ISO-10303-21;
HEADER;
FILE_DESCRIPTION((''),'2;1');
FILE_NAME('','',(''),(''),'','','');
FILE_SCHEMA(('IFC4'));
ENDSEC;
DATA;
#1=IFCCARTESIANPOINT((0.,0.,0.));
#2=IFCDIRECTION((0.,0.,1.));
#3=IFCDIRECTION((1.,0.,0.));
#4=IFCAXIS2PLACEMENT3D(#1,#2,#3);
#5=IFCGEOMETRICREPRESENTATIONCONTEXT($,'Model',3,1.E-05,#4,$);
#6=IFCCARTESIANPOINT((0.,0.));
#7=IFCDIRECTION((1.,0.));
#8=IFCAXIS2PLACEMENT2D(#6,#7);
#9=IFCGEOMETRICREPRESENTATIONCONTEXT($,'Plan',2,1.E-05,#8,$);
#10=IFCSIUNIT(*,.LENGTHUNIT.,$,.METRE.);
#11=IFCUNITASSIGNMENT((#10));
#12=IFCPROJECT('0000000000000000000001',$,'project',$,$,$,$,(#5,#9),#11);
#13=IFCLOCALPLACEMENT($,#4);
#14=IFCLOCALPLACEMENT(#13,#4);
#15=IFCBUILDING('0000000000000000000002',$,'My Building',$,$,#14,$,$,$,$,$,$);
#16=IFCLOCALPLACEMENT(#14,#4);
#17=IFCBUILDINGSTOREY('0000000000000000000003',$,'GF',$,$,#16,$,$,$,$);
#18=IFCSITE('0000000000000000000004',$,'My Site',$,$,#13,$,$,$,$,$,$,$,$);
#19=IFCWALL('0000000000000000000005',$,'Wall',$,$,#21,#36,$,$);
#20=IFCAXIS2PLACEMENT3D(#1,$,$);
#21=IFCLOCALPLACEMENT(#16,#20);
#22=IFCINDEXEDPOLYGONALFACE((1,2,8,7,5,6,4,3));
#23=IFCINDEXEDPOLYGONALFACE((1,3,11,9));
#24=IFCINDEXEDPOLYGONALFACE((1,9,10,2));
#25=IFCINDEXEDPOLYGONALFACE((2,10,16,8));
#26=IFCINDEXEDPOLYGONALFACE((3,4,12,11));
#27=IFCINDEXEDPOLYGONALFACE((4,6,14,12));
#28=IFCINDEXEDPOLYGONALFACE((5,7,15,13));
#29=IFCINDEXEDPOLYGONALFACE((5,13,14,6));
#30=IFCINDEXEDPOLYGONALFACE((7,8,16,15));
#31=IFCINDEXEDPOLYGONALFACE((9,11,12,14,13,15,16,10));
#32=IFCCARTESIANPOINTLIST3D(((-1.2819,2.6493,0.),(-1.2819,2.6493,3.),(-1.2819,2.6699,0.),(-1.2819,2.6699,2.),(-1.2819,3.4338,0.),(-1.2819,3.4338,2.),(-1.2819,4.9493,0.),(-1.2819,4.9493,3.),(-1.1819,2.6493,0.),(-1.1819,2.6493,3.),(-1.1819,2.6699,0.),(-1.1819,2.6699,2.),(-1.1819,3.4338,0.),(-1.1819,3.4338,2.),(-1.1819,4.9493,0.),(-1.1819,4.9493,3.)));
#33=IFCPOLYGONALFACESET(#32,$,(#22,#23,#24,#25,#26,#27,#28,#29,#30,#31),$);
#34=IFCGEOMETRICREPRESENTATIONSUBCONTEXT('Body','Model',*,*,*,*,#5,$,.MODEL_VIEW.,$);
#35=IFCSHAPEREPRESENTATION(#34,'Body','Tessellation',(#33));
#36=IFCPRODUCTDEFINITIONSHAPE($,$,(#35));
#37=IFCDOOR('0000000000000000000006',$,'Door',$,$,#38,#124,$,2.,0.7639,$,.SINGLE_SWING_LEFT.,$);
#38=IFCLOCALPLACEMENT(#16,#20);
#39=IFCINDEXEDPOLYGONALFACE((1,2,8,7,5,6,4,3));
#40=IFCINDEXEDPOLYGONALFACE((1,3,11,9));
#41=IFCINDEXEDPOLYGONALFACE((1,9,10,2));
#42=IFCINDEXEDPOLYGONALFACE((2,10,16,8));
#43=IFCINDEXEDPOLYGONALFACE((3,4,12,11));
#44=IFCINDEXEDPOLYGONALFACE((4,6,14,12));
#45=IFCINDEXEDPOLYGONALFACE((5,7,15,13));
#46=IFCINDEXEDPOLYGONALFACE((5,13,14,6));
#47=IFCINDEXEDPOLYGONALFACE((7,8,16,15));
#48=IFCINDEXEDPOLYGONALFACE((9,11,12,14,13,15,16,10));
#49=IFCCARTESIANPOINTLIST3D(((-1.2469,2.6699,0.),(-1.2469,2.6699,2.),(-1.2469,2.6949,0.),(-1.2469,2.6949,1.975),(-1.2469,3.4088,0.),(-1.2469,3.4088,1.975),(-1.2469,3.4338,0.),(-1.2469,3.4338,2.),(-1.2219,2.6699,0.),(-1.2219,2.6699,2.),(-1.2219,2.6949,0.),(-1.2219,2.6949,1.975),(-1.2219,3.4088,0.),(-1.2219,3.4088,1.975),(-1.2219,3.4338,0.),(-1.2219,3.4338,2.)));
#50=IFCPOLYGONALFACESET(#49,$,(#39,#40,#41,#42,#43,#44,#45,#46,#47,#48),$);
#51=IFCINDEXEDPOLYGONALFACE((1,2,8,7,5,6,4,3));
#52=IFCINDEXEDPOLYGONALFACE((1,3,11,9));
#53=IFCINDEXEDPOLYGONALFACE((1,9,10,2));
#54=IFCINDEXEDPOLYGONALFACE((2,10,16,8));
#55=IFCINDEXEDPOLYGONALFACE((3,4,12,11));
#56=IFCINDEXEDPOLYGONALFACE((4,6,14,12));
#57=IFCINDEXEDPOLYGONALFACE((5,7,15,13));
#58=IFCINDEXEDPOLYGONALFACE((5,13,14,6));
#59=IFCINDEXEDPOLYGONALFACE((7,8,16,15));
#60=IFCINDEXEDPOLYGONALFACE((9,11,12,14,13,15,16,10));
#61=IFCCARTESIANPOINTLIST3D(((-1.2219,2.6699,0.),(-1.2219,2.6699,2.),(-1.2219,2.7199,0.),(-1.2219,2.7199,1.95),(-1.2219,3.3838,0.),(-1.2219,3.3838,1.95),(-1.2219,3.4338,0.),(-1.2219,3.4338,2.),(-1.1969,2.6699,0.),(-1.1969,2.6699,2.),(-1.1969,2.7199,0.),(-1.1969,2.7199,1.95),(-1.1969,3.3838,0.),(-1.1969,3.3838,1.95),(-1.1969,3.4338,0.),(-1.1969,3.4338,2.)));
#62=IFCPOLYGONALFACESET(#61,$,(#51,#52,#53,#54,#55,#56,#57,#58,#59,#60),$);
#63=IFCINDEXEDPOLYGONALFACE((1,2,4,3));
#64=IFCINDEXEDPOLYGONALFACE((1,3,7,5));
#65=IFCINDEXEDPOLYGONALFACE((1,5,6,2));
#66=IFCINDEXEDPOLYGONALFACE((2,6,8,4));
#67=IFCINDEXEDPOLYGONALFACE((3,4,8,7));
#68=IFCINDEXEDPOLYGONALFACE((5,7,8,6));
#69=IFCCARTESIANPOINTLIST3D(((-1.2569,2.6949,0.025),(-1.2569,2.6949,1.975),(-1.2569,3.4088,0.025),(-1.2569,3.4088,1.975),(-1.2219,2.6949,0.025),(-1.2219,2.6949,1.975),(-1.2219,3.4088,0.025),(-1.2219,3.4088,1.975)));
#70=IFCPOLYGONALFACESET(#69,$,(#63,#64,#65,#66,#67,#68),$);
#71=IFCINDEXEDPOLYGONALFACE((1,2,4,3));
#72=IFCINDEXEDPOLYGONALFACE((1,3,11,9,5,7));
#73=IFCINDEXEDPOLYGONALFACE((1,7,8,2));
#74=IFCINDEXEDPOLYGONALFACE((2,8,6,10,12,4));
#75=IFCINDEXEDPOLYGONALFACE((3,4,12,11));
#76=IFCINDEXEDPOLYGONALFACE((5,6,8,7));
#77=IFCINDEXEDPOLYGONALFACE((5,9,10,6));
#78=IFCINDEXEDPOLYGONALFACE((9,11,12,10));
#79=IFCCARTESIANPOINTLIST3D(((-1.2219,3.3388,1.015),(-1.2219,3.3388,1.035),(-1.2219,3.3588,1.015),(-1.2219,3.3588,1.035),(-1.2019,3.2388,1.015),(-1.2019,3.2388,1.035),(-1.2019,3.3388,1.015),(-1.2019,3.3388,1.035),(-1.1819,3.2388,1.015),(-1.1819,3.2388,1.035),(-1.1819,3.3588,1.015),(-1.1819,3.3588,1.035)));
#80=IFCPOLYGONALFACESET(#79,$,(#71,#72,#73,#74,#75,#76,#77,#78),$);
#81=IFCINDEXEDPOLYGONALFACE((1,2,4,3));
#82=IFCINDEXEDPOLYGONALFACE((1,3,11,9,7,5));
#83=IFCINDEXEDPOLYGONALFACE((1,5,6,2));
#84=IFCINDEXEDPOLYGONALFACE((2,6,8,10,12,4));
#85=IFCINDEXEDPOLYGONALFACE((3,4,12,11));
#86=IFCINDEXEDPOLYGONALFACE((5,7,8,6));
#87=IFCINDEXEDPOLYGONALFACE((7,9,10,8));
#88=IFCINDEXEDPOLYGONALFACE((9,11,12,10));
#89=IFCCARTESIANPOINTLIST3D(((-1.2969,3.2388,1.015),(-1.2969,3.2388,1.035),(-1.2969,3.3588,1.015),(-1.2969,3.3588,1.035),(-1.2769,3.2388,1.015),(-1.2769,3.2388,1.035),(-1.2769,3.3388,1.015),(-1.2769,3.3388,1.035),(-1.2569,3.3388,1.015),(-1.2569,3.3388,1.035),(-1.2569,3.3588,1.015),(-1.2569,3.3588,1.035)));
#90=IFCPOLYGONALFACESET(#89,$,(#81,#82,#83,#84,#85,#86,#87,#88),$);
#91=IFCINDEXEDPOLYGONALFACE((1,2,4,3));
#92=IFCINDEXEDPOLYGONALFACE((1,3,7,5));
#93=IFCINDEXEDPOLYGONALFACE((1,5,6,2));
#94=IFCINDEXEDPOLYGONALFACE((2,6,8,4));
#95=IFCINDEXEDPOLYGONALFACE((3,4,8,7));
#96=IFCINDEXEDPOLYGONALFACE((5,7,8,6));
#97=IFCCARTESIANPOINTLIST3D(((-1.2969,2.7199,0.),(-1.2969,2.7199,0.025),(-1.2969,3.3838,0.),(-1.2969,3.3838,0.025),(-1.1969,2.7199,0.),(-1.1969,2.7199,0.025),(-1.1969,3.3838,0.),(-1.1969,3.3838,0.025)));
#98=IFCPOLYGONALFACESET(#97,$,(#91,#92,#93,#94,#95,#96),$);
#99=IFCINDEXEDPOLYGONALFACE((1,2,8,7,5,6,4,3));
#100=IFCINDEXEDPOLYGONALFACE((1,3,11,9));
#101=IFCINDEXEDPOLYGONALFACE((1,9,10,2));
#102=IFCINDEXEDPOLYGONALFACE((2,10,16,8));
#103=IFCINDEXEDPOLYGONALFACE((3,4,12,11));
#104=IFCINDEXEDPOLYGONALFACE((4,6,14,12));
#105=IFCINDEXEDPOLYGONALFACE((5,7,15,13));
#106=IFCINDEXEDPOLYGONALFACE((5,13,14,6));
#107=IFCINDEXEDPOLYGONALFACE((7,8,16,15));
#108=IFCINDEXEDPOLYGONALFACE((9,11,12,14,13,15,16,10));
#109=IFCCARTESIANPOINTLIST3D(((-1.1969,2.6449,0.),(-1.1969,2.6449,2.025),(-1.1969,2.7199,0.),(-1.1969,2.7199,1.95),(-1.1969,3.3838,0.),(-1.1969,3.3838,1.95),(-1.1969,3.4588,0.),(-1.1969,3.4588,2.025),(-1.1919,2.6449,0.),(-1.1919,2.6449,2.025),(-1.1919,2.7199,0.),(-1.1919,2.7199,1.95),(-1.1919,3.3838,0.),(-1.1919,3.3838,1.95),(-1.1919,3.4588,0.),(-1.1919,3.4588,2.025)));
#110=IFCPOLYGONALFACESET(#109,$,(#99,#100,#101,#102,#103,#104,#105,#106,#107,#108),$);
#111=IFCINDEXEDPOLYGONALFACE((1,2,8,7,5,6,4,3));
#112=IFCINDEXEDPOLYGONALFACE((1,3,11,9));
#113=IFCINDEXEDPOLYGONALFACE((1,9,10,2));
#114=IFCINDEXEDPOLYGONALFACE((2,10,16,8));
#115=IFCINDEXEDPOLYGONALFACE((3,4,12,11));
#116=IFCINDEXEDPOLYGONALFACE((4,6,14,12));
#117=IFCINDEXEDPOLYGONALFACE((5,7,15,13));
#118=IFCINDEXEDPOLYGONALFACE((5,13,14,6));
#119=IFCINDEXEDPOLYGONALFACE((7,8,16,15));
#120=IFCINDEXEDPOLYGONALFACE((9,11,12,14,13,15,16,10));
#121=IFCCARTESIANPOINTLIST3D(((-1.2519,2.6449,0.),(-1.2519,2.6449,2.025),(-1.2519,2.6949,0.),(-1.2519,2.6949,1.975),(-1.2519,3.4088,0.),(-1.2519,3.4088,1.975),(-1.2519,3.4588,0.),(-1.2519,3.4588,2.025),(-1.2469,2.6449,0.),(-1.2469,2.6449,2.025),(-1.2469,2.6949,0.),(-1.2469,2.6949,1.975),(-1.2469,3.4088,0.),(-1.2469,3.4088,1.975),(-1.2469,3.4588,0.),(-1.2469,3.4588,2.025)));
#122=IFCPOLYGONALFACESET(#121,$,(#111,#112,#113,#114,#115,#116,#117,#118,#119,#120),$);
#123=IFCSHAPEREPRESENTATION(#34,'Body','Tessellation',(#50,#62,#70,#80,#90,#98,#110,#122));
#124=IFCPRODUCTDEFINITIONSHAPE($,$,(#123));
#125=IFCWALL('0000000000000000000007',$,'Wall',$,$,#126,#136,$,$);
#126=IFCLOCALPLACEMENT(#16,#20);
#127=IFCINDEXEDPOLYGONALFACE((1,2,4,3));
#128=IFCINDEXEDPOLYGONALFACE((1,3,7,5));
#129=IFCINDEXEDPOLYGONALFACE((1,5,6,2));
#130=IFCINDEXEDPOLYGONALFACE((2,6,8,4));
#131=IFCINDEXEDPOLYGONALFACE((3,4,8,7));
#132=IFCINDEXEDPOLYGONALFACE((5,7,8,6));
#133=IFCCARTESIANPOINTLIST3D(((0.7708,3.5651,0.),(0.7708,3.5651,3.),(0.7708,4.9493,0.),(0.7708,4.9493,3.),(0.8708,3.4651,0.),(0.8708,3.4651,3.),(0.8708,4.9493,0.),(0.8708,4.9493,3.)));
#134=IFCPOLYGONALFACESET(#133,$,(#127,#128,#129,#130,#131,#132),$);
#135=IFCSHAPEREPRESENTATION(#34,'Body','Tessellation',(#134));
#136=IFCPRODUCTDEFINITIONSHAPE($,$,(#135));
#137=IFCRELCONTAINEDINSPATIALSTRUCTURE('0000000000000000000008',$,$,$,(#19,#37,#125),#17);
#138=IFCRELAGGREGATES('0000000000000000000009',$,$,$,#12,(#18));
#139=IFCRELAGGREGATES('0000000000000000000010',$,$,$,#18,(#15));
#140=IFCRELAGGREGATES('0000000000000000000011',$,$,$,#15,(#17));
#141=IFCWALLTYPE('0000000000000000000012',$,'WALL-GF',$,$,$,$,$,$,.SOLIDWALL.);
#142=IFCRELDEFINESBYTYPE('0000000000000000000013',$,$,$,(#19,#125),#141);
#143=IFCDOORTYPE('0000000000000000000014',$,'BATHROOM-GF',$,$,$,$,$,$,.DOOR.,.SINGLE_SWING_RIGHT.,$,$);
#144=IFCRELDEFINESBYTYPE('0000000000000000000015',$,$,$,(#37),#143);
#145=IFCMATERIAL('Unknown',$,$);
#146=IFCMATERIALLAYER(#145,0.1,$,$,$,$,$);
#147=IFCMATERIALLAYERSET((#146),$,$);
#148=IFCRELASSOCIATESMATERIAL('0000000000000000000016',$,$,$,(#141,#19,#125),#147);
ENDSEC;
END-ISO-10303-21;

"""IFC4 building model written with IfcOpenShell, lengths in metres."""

from ifc_helpers import new_model, entity, si_unit, frame, origin_with_axes, origin_2d_with_axis, place, context, subcontext, project, spatial, line, indexed_curve, outline, extrude, shape, source, transform, mapped, material, layer, layer_set, layer_usage, type_object, type_shapes, element, fill, save


model = new_model("IFC4")

# Units and contexts
model_context = context("Model", 3, precision=1e-05, world=origin_with_axes())
plan_context = context("Plan", 2, precision=1e-05, world=origin_2d_with_axis())
body_context_1 = subcontext(model_context, "Body", "Model", "MODEL_VIEW")
body_context_2 = subcontext(plan_context, "Body", "Plan", "PLAN_VIEW")
ifc_project = project(units=[si_unit("LENGTHUNIT", "METRE")], contexts=[model_context, plan_context])

# Site, building, storey
site_placement = place(None, origin_with_axes())
site = spatial("IfcSite", under=ifc_project, at=site_placement, Name="My Site")
building_placement = place(site_placement, origin_with_axes())
building = spatial("IfcBuilding", under=site, at=building_placement, Name="My Building")
storey_placement = place(building_placement, origin_with_axes())
storey = spatial("IfcBuildingStorey", under=building, at=storey_placement, Name="GF")

# Shared definitions
ifc_material = material(Name="Unknown")

# Shared definitions
ifc_layer_1 = layer(ifc_material, 0.1)
ifc_layer_set_1 = layer_set([ifc_layer_1])
wall_type = type_object("IfcWallType", Name="WALL-GF", PredefinedType="SOLIDWALL", material=ifc_layer_set_1)

# Wall, opening, door
ifc_layer_usage_1 = layer_usage(ifc_layer_set_1, "AXIS2", "POSITIVE", 0.0)
wall_1_placement = place(storey_placement, frame((-1.1819, 2.6493, 0.0), z_axis=(0.0, 0.0, 1.0), x_axis=(0.0, 1.0, 0.0)))
wall_1 = element("IfcWall", 1, at=wall_1_placement, inside=storey, type_object=wall_type, material=ifc_layer_usage_1, Name="Wall", context=body_context_1, shape_type="SweptSolid", body=[
    extrude(outline(indexed_curve([(0.0, 0.0), (0.0, 0.1), (2.3, 0.1), (2.3, 0.0)], segments=[line(1, 2, 3, 4, 1)])), origin_with_axes(), (0.0, 0.0, 1.0), 3.0),
])
shared_shape_1 = source(origin_with_axes(), body_context_1, "Body", "SweptSolid", [
    extrude(outline(indexed_curve([(0.0, 0.0), (0.7639, 0.0), (0.7639, 2.0), (0.0, 2.0)], segments=[line(1, 2, 3, 4, 1)])), frame((0.0, -0.6, 0.0), z_axis=(0.0, -1.0, 0.0), x_axis=(1.0, 0.0, 0.0)), (0.0, 0.0, -1.0), 1.2),
])
opening_1_placement = place(wall_1_placement, frame((0.0206, 0.015, 0.0), z_axis=(0.0, 0.0, 1.0), x_axis=(1.0, 0.0, 0.0)))
opening_1 = element("IfcOpeningElement", 2, at=opening_1_placement, cuts=wall_1, PredefinedType="OPENING", context=body_context_1, shape_type="MappedRepresentation", body=[
    mapped(shared_shape_1, transform((0.0, 0.0, 0.0), x_axis=(1.0, 0.0, 0.0), y_axis=(0.0, 1.0, 0.0), z_axis=(0.0, 0.0, 1.0), scale=1.0)),
])
door_type_1 = type_object("IfcDoorType", Name="BATHROOM-GF", OperationType="SINGLE_SWING_RIGHT", PredefinedType="DOOR")
shared_shape_2 = source(origin_with_axes(), body_context_1, "Body", "SweptSolid", [
    extrude(outline(indexed_curve([(0.0, 0.0), (0.0, 2.0), (0.7639, 2.0), (0.7639, 0.0), (0.7389, 0.0), (0.7389, 1.975), (0.025, 1.975), (0.025, 0.0)], segments=[line(1, 2, 3, 4, 5, 6, 7, 8, 1)])), frame((0.0, 0.025, 0.0), z_axis=(0.0, -1.0, 0.0), x_axis=(1.0, 0.0, 0.0)), (0.0, 0.0, -1.0), 0.025),
    extrude(outline(indexed_curve([(0.0, 0.0), (0.0, 2.0), (0.7639, 2.0), (0.7639, 0.0), (0.7139, 0.0), (0.7139, 1.95), (0.05, 1.95), (0.05, 0.0)], segments=[line(1, 2, 3, 4, 5, 6, 7, 8, 1)])), frame((0.0, 0.0, 0.0), z_axis=(0.0, -1.0, 0.0), x_axis=(1.0, 0.0, 0.0)), (0.0, 0.0, -1.0), 0.025),
    extrude(outline(indexed_curve([(0.0, 0.0), (0.7139, 0.0), (0.7139, 0.035), (0.0, 0.035)], segments=[line(1, 2, 3, 4, 1)])), frame((0.025, 0.025, 0.025), z_axis=(0.0, 0.0, 1.0), x_axis=(1.0, 0.0, 0.0)), (0.0, 0.0, 1.0), 1.95),
    extrude(outline(indexed_curve([(0.0, 0.0), (0.0, -0.04), (-0.12, -0.04), (-0.12, -0.02), (-0.02, -0.02), (-0.02, 0.0)], segments=[line(1, 2, 3, 4, 5, 6, 1)])), frame((0.6889, 0.025, 1.015), z_axis=(0.0, 0.0, 1.0), x_axis=(1.0, 0.0, 0.0)), (0.0, 0.0, 1.0), 0.02),
    extrude(outline(indexed_curve([(0.0, 0.0), (0.0, 0.04), (-0.12, 0.04), (-0.12, 0.02), (-0.02, 0.02), (-0.02, 0.0)], segments=[line(1, 2, 3, 4, 5, 6, 1)])), frame((0.6889, 0.06, 1.015), z_axis=(0.0, 0.0, 1.0), x_axis=(1.0, 0.0, 0.0)), (0.0, 0.0, 1.0), 0.02),
    extrude(outline(indexed_curve([(0.0, 0.0), (0.6639, 0.0), (0.6639, 0.1), (0.0, 0.1)], segments=[line(1, 2, 3, 4, 1)])), frame((0.05, 0.0, 0.0), z_axis=(0.0, 0.0, 1.0), x_axis=(1.0, 0.0, 0.0)), (0.0, 0.0, 1.0), 0.025),
    extrude(outline(indexed_curve([(0.0, 0.0), (0.0, 2.025), (0.8139, 2.025), (0.8139, 0.0), (0.7389, 0.0), (0.7389, 1.95), (0.075, 1.95), (0.075, 0.0)], segments=[line(1, 2, 3, 4, 5, 6, 7, 8, 1)])), frame((-0.025, -0.005, 0.0), z_axis=(0.0, -1.0, 0.0), x_axis=(1.0, 0.0, 0.0)), (0.0, 0.0, -1.0), 0.005),
    extrude(outline(indexed_curve([(0.0, 0.0), (0.0, 2.025), (0.8139, 2.025), (0.8139, 0.0), (0.7639, 0.0), (0.7639, 1.975), (0.05, 1.975), (0.05, 0.0)], segments=[line(1, 2, 3, 4, 5, 6, 7, 8, 1)])), frame((-0.025, 0.05, 0.0), z_axis=(0.0, -1.0, 0.0), x_axis=(1.0, 0.0, 0.0)), (0.0, 0.0, -1.0), 0.005),
])
shared_shape_3 = source(origin_with_axes(), body_context_2, "Body", "Curve2D", [
    entity("IfcIndexedPolyCurve", entity("IfcCartesianPointList2D", [[0.0, 0.0], [0.0, 0.05], [0.025, 0.05], [0.025, 0.025], [0.05, 0.025], [0.05, 0.0]]), [entity("IfcLineIndex", [1, 2, 3, 4, 5, 6, 1])]),
    entity("IfcIndexedPolyCurve", entity("IfcCartesianPointList2D", [[0.7639, 0.0], [0.7639, 0.05], [0.7389, 0.05], [0.7389, 0.025], [0.7139, 0.025], [0.7139, 0.0]]), [entity("IfcLineIndex", [1, 2, 3, 4, 5, 6, 1])]),
    entity("IfcTrimmedCurve", entity("IfcEllipse", entity("IfcAxis2Placement2D", entity("IfcCartesianPoint", [0.06, 0.05]), entity("IfcDirection", [1.0, 0.0])), 0.6789, 0.7139), [entity("IfcCartesianPoint", [0.7389, 0.05])], [entity("IfcCartesianPoint", [0.06, 0.7639])], True, "CARTESIAN"),
    entity("IfcIndexedPolyCurve", entity("IfcCartesianPointList2D", [[0.025, 0.05], [0.06, 0.05], [0.06, 0.7639], [0.025, 0.7639]]), [entity("IfcLineIndex", [1, 2, 3, 4, 1])]),
])
type_shapes(door_type_1, [shared_shape_2, shared_shape_3])
door_1_placement = place(opening_1_placement, origin_with_axes())
door_1 = element("IfcDoor", 3, at=door_1_placement, inside=storey, type_object=door_type_1, Name="Door", OperationType="SINGLE_SWING_LEFT", OverallHeight=2.0, OverallWidth=0.7639, shapes=[
    shape(body_context_1, "Body", "MappedRepresentation", [mapped(shared_shape_2, transform((0.0, 0.0, 0.0), x_axis=(1.0, 0.0, 0.0), y_axis=(0.0, 1.0, 0.0), z_axis=(0.0, 0.0, 1.0), scale=1.0))]),
    shape(body_context_2, "Body", "MappedRepresentation", [mapped(shared_shape_3, transform((0.0, 0.0, 0.0), x_axis=(1.0, 0.0, 0.0), y_axis=(0.0, 1.0, 0.0), z_axis=(0.0, 0.0, 1.0), scale=1.0))]),
])
fill(opening_1, door_1)

# Wall
ifc_layer_usage_2 = layer_usage(ifc_layer_set_1, "AXIS2", "POSITIVE", 0.0)
wall_2_placement = place(storey_placement, frame((0.7708, 5.0493, 0.0), z_axis=(0.0, 0.0, 1.0), x_axis=(0.0, -1.0, 0.0)))
element("IfcWall", 4, at=wall_2_placement, inside=storey, type_object=wall_type, material=ifc_layer_usage_2, Name="Wall", context=body_context_1, shape_type="SweptSolid", body=[
    extrude(outline(indexed_curve([(0.1, 0.0), (0.1, 0.1), (1.5842, 0.1), (1.4842, 0.0)], segments=[line(1, 2, 3, 4, 1)])), origin_with_axes(), (0.0, 0.0, 1.0), 3.0),
])

save(model, "model.ifc")
